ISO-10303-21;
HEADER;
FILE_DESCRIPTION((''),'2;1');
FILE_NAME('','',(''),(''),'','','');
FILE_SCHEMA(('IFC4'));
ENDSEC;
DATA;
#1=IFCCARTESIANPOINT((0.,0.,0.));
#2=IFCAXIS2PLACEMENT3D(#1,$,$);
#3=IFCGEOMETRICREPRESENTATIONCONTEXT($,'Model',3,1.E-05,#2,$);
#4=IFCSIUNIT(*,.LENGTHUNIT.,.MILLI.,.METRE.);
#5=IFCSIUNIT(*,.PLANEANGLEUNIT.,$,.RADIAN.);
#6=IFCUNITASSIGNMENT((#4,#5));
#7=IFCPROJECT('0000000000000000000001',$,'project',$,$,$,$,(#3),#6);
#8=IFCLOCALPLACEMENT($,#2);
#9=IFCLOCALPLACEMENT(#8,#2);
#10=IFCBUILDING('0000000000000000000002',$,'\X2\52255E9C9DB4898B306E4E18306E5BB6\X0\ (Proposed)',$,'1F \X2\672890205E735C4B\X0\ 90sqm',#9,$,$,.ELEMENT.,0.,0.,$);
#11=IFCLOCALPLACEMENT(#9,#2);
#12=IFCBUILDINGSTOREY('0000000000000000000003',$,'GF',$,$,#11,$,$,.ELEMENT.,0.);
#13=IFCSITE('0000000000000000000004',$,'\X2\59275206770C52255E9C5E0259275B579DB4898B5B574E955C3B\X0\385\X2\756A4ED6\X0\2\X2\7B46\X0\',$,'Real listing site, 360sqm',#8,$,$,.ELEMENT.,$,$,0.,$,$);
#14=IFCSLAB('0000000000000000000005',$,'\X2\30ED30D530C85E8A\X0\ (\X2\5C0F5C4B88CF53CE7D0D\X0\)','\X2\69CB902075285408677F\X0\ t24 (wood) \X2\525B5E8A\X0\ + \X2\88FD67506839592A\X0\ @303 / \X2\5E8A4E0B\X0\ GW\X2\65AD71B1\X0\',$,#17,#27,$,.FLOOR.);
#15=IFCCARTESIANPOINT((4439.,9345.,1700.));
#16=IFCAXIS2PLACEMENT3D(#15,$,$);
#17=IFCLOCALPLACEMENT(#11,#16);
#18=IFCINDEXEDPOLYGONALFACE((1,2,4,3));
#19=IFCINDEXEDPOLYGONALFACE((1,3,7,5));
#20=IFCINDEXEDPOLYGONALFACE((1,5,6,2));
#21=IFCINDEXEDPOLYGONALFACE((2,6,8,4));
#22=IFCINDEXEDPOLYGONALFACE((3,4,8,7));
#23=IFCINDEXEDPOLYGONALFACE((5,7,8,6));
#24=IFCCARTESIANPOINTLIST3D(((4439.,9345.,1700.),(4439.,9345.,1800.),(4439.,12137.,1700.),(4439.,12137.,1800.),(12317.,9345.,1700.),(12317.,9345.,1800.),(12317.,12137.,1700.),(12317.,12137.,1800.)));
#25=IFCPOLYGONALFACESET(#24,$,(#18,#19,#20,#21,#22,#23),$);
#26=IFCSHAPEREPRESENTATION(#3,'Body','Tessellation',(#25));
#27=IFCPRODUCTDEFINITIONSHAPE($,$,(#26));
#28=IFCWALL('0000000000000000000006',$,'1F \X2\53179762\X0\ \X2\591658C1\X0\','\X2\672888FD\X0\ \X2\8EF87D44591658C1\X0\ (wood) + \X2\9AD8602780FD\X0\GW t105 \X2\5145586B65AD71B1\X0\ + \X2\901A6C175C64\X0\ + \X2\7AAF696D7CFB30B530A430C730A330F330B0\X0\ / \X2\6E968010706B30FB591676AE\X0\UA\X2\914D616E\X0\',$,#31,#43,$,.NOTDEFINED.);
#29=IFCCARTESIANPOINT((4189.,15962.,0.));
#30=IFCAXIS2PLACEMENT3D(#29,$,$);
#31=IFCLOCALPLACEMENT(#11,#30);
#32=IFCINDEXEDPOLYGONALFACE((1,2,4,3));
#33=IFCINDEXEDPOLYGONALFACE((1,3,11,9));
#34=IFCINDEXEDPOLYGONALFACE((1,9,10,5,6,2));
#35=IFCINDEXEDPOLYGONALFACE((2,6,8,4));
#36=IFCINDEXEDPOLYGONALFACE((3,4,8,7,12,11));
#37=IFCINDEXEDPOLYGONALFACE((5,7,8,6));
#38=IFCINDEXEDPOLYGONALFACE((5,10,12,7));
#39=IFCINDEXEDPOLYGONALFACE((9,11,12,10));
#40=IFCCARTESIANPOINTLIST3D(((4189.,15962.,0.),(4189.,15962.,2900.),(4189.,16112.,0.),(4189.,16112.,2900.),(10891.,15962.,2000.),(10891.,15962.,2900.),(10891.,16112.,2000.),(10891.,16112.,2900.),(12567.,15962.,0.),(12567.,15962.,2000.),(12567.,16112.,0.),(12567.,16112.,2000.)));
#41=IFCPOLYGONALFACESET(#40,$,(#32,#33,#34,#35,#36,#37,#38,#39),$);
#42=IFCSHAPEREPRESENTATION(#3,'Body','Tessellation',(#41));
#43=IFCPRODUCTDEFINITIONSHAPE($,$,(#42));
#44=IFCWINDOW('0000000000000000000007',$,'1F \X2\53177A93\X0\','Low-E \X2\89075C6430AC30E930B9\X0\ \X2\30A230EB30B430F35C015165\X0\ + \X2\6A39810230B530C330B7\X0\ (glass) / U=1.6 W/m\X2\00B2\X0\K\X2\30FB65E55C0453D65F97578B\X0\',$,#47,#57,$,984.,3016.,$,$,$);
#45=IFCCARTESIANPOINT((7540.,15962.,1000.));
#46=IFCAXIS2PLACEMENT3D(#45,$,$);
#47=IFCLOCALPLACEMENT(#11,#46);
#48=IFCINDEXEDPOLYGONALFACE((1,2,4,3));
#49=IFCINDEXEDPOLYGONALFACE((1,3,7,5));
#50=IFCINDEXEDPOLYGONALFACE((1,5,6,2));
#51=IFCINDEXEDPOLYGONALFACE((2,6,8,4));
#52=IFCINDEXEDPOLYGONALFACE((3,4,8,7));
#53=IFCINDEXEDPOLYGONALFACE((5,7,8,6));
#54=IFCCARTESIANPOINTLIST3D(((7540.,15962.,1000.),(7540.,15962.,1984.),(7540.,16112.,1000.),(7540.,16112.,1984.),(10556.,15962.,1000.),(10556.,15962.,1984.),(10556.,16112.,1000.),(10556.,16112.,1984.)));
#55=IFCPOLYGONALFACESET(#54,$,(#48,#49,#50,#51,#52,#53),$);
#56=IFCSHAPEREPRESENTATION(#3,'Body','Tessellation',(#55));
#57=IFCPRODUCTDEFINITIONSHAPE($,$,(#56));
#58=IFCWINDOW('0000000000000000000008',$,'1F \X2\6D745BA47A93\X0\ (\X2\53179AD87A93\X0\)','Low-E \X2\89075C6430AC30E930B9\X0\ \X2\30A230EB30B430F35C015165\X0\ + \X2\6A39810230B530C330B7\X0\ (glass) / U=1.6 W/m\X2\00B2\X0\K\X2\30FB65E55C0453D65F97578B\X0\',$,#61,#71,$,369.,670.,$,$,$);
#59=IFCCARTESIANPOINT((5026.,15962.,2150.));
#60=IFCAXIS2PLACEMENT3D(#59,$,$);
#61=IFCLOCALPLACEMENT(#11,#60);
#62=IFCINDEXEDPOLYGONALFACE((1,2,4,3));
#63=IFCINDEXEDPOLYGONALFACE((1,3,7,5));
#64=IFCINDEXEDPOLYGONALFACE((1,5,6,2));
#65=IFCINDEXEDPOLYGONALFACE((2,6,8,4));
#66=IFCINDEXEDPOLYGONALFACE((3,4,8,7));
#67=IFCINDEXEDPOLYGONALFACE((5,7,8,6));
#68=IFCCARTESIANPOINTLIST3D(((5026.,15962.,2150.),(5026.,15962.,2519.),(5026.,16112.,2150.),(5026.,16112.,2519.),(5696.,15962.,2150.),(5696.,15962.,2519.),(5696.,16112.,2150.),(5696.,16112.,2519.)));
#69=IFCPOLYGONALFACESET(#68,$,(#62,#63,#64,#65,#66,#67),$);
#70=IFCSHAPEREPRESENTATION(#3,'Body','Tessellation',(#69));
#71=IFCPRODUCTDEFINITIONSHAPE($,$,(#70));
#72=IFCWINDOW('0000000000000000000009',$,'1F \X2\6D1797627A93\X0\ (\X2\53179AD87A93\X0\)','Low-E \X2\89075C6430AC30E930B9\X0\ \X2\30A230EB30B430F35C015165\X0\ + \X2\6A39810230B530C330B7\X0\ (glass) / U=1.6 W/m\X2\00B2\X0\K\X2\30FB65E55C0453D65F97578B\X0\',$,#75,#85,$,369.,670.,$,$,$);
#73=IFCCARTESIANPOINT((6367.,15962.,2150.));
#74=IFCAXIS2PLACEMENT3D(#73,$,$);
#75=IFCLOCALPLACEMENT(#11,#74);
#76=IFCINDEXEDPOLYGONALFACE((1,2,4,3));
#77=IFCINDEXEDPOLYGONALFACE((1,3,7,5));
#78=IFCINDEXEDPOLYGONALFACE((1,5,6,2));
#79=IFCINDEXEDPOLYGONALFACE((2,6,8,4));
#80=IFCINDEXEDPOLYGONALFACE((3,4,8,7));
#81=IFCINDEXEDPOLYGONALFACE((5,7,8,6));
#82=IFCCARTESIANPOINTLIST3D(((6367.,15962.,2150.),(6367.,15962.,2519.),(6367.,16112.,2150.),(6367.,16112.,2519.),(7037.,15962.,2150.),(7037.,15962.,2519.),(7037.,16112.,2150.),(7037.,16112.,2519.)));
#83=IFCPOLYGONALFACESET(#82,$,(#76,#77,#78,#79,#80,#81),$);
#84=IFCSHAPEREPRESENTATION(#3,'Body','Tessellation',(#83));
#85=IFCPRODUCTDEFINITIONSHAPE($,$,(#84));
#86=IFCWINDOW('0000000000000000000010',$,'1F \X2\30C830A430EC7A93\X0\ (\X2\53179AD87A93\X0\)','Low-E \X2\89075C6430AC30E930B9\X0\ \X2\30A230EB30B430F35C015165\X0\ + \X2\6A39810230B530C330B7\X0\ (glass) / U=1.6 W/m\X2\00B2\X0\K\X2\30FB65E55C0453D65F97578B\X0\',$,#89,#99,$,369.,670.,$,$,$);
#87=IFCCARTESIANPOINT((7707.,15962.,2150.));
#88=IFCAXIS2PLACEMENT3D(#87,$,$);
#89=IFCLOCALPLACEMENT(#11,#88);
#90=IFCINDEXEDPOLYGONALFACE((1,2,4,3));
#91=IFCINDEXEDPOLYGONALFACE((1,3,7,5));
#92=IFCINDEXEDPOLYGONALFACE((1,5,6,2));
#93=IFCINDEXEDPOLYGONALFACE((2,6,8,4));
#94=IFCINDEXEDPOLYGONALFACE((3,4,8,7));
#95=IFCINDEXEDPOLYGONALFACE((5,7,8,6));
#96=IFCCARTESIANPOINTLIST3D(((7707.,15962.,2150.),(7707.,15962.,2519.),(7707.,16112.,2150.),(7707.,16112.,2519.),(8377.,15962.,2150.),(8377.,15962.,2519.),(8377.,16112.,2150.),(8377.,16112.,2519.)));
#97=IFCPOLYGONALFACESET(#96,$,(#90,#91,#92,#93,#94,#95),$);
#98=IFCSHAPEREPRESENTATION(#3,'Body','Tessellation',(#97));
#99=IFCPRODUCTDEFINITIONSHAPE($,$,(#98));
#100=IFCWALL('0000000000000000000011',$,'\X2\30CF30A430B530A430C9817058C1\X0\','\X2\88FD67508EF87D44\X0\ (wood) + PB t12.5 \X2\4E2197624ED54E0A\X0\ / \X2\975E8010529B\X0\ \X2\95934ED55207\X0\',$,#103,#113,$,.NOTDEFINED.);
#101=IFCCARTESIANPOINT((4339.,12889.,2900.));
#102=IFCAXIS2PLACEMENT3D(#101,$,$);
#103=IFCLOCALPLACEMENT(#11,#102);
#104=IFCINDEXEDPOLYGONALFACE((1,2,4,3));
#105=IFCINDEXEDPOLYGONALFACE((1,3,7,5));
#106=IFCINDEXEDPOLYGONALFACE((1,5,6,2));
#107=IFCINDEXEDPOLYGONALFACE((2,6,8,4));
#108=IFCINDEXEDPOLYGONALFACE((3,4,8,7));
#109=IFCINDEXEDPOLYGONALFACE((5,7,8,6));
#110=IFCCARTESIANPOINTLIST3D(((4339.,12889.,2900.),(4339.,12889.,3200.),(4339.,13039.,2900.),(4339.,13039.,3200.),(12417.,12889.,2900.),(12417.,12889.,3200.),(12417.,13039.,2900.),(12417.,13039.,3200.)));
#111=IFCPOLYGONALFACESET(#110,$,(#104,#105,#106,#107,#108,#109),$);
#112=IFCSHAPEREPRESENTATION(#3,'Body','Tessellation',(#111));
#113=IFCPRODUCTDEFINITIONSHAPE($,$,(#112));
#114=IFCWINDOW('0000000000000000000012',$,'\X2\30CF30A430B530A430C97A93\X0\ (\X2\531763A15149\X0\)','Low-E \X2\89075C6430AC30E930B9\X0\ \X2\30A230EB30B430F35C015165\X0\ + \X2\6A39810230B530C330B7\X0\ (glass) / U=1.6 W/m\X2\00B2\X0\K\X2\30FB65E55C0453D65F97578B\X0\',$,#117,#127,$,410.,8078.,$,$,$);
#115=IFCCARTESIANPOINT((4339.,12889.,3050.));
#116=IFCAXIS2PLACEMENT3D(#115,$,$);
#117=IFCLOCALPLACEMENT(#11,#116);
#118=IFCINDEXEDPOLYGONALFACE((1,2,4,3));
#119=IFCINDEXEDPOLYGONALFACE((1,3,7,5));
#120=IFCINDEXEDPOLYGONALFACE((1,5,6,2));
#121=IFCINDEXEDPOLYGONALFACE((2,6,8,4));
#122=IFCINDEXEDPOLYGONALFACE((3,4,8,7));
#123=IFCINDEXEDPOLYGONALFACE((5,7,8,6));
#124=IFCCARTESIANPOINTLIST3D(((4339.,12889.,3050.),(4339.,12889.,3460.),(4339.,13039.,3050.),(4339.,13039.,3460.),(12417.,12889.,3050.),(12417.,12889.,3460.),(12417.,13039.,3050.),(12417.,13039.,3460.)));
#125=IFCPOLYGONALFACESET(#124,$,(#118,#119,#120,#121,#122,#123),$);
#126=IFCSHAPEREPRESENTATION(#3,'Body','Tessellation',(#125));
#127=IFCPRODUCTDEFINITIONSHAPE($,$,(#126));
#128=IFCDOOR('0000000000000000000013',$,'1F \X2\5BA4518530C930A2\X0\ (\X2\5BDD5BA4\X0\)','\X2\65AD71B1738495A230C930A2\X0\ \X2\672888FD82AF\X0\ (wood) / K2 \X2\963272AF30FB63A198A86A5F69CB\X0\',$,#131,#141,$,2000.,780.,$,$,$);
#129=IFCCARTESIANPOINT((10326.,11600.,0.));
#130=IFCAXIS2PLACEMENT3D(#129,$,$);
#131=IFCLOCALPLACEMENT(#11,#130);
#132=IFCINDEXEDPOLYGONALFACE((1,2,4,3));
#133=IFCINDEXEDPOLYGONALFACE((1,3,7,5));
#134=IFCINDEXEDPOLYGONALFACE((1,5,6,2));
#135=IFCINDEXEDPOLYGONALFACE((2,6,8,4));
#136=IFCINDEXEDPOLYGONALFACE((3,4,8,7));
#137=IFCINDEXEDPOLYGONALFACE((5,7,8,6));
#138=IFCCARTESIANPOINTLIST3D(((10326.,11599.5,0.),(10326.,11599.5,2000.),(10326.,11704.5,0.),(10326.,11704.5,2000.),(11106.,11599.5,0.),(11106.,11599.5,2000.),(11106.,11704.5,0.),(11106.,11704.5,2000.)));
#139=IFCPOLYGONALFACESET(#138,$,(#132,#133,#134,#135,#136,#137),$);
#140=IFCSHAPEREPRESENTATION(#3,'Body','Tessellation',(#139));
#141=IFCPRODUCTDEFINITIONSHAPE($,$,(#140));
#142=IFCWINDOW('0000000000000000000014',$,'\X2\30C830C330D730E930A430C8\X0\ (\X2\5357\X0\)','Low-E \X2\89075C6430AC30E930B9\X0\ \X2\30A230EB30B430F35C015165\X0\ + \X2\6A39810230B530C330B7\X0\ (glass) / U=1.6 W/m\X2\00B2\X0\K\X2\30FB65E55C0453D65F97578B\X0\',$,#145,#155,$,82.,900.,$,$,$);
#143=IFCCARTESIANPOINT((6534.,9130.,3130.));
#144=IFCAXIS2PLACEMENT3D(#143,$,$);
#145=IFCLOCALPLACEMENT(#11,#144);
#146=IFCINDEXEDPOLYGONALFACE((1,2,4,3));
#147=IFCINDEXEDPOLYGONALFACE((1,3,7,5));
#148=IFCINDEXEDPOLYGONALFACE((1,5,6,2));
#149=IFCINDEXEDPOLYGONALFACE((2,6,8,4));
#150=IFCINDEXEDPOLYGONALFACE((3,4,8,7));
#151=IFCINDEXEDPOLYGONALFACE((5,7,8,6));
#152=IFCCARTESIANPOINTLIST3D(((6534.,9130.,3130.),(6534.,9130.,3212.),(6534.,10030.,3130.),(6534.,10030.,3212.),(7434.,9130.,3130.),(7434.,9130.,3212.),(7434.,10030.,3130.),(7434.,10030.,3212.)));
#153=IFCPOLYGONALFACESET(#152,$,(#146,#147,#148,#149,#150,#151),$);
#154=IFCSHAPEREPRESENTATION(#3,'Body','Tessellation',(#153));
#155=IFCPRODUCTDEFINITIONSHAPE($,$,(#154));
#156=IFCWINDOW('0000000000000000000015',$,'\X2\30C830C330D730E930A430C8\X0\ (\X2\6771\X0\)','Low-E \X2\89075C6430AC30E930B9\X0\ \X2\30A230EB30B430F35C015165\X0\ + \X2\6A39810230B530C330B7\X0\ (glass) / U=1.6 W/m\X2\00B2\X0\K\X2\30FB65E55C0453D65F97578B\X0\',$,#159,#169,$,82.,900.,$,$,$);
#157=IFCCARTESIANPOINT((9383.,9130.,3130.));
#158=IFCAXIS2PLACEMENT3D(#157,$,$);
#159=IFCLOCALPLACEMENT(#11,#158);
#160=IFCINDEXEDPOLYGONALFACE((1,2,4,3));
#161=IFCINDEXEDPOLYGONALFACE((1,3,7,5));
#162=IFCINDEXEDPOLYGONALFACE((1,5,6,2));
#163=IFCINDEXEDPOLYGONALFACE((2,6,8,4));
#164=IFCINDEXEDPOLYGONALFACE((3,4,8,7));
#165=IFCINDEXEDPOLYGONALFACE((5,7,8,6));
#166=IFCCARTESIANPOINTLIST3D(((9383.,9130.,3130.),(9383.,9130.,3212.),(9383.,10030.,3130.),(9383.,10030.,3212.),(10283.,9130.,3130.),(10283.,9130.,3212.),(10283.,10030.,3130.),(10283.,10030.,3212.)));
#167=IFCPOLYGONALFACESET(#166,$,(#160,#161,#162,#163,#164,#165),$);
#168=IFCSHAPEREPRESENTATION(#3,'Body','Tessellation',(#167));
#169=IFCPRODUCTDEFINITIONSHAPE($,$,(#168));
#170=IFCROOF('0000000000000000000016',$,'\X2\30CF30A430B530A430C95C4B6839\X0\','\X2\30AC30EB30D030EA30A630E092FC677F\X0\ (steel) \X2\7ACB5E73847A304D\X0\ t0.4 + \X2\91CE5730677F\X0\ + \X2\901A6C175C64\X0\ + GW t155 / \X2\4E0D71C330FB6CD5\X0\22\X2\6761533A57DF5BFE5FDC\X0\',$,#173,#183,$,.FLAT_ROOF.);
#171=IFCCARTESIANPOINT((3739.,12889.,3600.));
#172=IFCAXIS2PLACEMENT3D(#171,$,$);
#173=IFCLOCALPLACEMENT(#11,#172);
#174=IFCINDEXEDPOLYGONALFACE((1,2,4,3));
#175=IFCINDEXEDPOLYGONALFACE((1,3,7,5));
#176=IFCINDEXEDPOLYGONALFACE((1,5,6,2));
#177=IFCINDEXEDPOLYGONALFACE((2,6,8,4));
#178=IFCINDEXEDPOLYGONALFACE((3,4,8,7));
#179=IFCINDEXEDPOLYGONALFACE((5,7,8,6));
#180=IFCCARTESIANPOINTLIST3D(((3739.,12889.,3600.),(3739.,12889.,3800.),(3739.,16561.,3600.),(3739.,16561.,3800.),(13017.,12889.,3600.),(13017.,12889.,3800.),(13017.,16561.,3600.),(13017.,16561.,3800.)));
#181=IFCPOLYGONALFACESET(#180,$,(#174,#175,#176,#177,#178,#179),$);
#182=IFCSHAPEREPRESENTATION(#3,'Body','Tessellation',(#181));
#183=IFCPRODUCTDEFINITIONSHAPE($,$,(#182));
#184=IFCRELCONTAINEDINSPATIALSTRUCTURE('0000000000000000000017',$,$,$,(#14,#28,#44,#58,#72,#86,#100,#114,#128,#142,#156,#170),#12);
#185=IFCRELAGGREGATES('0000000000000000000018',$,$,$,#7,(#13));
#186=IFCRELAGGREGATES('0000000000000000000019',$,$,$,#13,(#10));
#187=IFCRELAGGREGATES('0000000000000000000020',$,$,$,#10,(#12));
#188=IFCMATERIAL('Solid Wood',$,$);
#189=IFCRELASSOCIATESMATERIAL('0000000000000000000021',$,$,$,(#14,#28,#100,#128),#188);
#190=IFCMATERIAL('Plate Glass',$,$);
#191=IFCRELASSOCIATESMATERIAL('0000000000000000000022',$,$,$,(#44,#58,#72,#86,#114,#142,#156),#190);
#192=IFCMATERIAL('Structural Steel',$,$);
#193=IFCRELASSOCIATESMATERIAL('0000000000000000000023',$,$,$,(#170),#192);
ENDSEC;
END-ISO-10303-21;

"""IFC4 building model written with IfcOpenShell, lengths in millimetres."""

from ifc_helpers import new_model, si_unit, frame, frame_2d, origin, place, context, project, spatial, rectangle, extrude, material, element, fill, save


model = new_model("IFC4")

# Units and contexts
model_context = context("Model", 3, precision=1e-05, world=origin())
ifc_project = project(units=[si_unit("LENGTHUNIT", "METRE", prefix="MILLI"), si_unit("PLANEANGLEUNIT", "RADIAN")], contexts=[model_context])

# Site, building, storey
site_placement = place(None, origin())
site = spatial("IfcSite", under=ifc_project, at=site_placement, Name="大分県別府市大字鶴見字井尻385番他2筆", ObjectType="Real listing site, 360sqm", CompositionType="ELEMENT", RefElevation=0.0)
building_placement = place(site_placement, origin())
building = spatial("IfcBuilding", under=site, at=building_placement, Name="別府鶴見の丘の家 (Proposed)", ObjectType="1F 木造平屋 90sqm", CompositionType="ELEMENT", ElevationOfRefHeight=0.0, ElevationOfTerrain=0.0)
storey_placement = place(building_placement, origin())
storey = spatial("IfcBuildingStorey", under=building, at=storey_placement, Name="GF", CompositionType="ELEMENT", Elevation=0.0)

# Slab
ifc_material_1 = material(Name="Solid Wood")
slab_placement = place(storey_placement, frame((4439.0, 9345.0, 1700.0)))
element("IfcSlab", 1, at=slab_placement, inside=storey, material=ifc_material_1, Name="ロフト床 (小屋裏収納)", Description="構造用合板 t24 (wood) 剛床 + 製材根太 @303 / 床下 GW断熱", PredefinedType="FLOOR", context=model_context, shape_type="SweptSolid", body=[
    extrude(rectangle(XDim=7878.0, YDim=2792.0, at=frame_2d((3939.0, 1396.0))), frame((4439.0, 9345.0, 1700.0)), (0.0, 0.0, 1.0), 100.0),
])

# Wall, openings, windows
wall_1_placement = place(storey_placement, frame((4189.0, 15962.0, 0.0)))
wall_1 = element("IfcWall", 2, at=wall_1_placement, inside=storey, material=ifc_material_1, Name="1F 北面 外壁", Description="木製 軸組外壁 (wood) + 高性能GW t105 充填断熱 + 通気層 + 窯業系サイディング / 準耐火・外皮UA配慮", PredefinedType="NOTDEFINED", context=model_context, shape_type="SweptSolid", body=[
    extrude(rectangle(XDim=8378.0, YDim=150.0, at=frame_2d((4189.0, 75.0))), frame((4189.0, 15962.0, 0.0)), (0.0, 0.0, 1.0), 2900.0),
])
opening_1_placement = place(storey_placement, frame((7540.0, 15962.0, 1000.0)))
opening_1 = element("IfcOpeningElement", 3, at=opening_1_placement, cuts=wall_1, PredefinedType="NOTDEFINED", context=model_context, shape_type="SweptSolid", body=[
    extrude(rectangle(XDim=3016.0, YDim=150.0, at=frame_2d((1508.0, 75.0))), frame((7540.0, 15962.0, 1000.0)), (0.0, 0.0, 1.0), 984.0),
])
opening_2_placement = place(storey_placement, frame((5026.0, 15962.0, 2150.0)))
opening_2 = element("IfcOpeningElement", 4, at=opening_2_placement, cuts=wall_1, PredefinedType="NOTDEFINED", context=model_context, shape_type="SweptSolid", body=[
    extrude(rectangle(XDim=670.0, YDim=150.0, at=frame_2d((335.0, 75.0))), frame((5026.0, 15962.0, 2150.0)), (0.0, 0.0, 1.0), 369.0),
])
opening_3_placement = place(storey_placement, frame((6367.0, 15962.0, 2150.0)))
opening_3 = element("IfcOpeningElement", 5, at=opening_3_placement, cuts=wall_1, PredefinedType="NOTDEFINED", context=model_context, shape_type="SweptSolid", body=[
    extrude(rectangle(XDim=670.0, YDim=150.0, at=frame_2d((335.0, 75.0))), frame((6367.0, 15962.0, 2150.0)), (0.0, 0.0, 1.0), 369.0),
])
opening_4_placement = place(storey_placement, frame((7707.0, 15962.0, 2150.0)))
opening_4 = element("IfcOpeningElement", 6, at=opening_4_placement, cuts=wall_1, PredefinedType="NOTDEFINED", context=model_context, shape_type="SweptSolid", body=[
    extrude(rectangle(XDim=670.0, YDim=150.0, at=frame_2d((335.0, 75.0))), frame((7707.0, 15962.0, 2150.0)), (0.0, 0.0, 1.0), 369.0),
])
ifc_material_2 = material(Name="Plate Glass")
window_1_placement = place(storey_placement, frame((7540.0, 15962.0, 1000.0)))
window_1 = element("IfcWindow", 7, at=window_1_placement, inside=storey, material=ifc_material_2, Name="1F 北窓", Description="Low-E 複層ガラス アルゴン封入 + 樹脂サッシ (glass) / U=1.6 W/m²K・日射取得型", OverallHeight=984.0, OverallWidth=3016.0, context=model_context, shape_type="SweptSolid", body=[
    extrude(rectangle(XDim=3016.0, YDim=150.0, at=frame_2d((1508.0, 75.0))), frame((7540.0, 15962.0, 1000.0)), (0.0, 0.0, 1.0), 984.0),
])
fill(opening_1, window_1)
window_2_placement = place(storey_placement, frame((5026.0, 15962.0, 2150.0)))
window_2 = element("IfcWindow", 8, at=window_2_placement, inside=storey, material=ifc_material_2, Name="1F 浴室窓 (北高窓)", Description="Low-E 複層ガラス アルゴン封入 + 樹脂サッシ (glass) / U=1.6 W/m²K・日射取得型", OverallHeight=369.0, OverallWidth=670.0, context=model_context, shape_type="SweptSolid", body=[
    extrude(rectangle(XDim=670.0, YDim=150.0, at=frame_2d((335.0, 75.0))), frame((5026.0, 15962.0, 2150.0)), (0.0, 0.0, 1.0), 369.0),
])
fill(opening_2, window_2)
window_3_placement = place(storey_placement, frame((6367.0, 15962.0, 2150.0)))
window_3 = element("IfcWindow", 9, at=window_3_placement, inside=storey, material=ifc_material_2, Name="1F 洗面窓 (北高窓)", Description="Low-E 複層ガラス アルゴン封入 + 樹脂サッシ (glass) / U=1.6 W/m²K・日射取得型", OverallHeight=369.0, OverallWidth=670.0, context=model_context, shape_type="SweptSolid", body=[
    extrude(rectangle(XDim=670.0, YDim=150.0, at=frame_2d((335.0, 75.0))), frame((6367.0, 15962.0, 2150.0)), (0.0, 0.0, 1.0), 369.0),
])
fill(opening_3, window_3)
window_4_placement = place(storey_placement, frame((7707.0, 15962.0, 2150.0)))
window_4 = element("IfcWindow", 10, at=window_4_placement, inside=storey, material=ifc_material_2, Name="1F トイレ窓 (北高窓)", Description="Low-E 複層ガラス アルゴン封入 + 樹脂サッシ (glass) / U=1.6 W/m²K・日射取得型", OverallHeight=369.0, OverallWidth=670.0, context=model_context, shape_type="SweptSolid", body=[
    extrude(rectangle(XDim=670.0, YDim=150.0, at=frame_2d((335.0, 75.0))), frame((7707.0, 15962.0, 2150.0)), (0.0, 0.0, 1.0), 369.0),
])
fill(opening_4, window_4)

# Wall, opening, window
wall_2_placement = place(storey_placement, frame((4339.0, 12889.0, 2900.0)))
wall_2 = element("IfcWall", 11, at=wall_2_placement, inside=storey, material=ifc_material_1, Name="ハイサイド腰壁", Description="製材軸組 (wood) + PB t12.5 両面仕上 / 非耐力 間仕切", PredefinedType="NOTDEFINED", context=model_context, shape_type="SweptSolid", body=[
    extrude(rectangle(XDim=8078.0, YDim=150.0, at=frame_2d((4039.0, 75.0))), frame((4339.0, 12889.0, 2900.0)), (0.0, 0.0, 1.0), 700.0),
])
opening_5_placement = place(storey_placement, frame((4339.0, 12889.0, 3050.0)))
opening_5 = element("IfcOpeningElement", 12, at=opening_5_placement, cuts=wall_2, PredefinedType="NOTDEFINED", context=model_context, shape_type="SweptSolid", body=[
    extrude(rectangle(XDim=8078.0, YDim=150.0, at=frame_2d((4039.0, 75.0))), frame((4339.0, 12889.0, 3050.0)), (0.0, 0.0, 1.0), 410.0),
])
window_5_placement = place(storey_placement, frame((4339.0, 12889.0, 3050.0)))
window_5 = element("IfcWindow", 13, at=window_5_placement, inside=storey, material=ifc_material_2, Name="ハイサイド窓 (北採光)", Description="Low-E 複層ガラス アルゴン封入 + 樹脂サッシ (glass) / U=1.6 W/m²K・日射取得型", OverallHeight=410.0, OverallWidth=8078.0, context=model_context, shape_type="SweptSolid", body=[
    extrude(rectangle(XDim=8078.0, YDim=150.0, at=frame_2d((4039.0, 75.0))), frame((4339.0, 12889.0, 3050.0)), (0.0, 0.0, 1.0), 410.0),
])
fill(opening_5, window_5)

# Door
door_1_placement = place(storey_placement, frame((10326.0, 11600.0, 0.0)))
element("IfcDoor", 14, at=door_1_placement, inside=storey, material=ifc_material_1, Name="1F 室内ドア (寝室)", Description="断熱玄関ドア 木製芯 (wood) / K2 防犯・採風機構", OverallHeight=2000.0, OverallWidth=780.0, context=model_context, shape_type="SweptSolid", body=[
    extrude(rectangle(XDim=780.0, YDim=105.0, at=frame_2d((390.0, 52.0))), frame((10326.0, 11600.0, 0.0)), (0.0, 0.0, 1.0), 2000.0),
])

# Windows
window_6_placement = place(storey_placement, frame((6534.0, 9130.0, 3130.0)))
element("IfcWindow", 15, at=window_6_placement, inside=storey, material=ifc_material_2, Name="トップライト (南)", Description="Low-E 複層ガラス アルゴン封入 + 樹脂サッシ (glass) / U=1.6 W/m²K・日射取得型", OverallHeight=82.0, OverallWidth=900.0, context=model_context, shape_type="SweptSolid", body=[
    extrude(rectangle(XDim=900.0, YDim=900.0, at=frame_2d((450.0, 450.0))), frame((6534.0, 9130.0, 3130.0)), (0.0, 0.0, 1.0), 82.0),
])
window_7_placement = place(storey_placement, frame((9383.0, 9130.0, 3130.0)))
element("IfcWindow", 16, at=window_7_placement, inside=storey, material=ifc_material_2, Name="トップライト (東)", Description="Low-E 複層ガラス アルゴン封入 + 樹脂サッシ (glass) / U=1.6 W/m²K・日射取得型", OverallHeight=82.0, OverallWidth=900.0, context=model_context, shape_type="SweptSolid", body=[
    extrude(rectangle(XDim=900.0, YDim=900.0, at=frame_2d((450.0, 450.0))), frame((9383.0, 9130.0, 3130.0)), (0.0, 0.0, 1.0), 82.0),
])

# Roof
ifc_material_3 = material(Name="Structural Steel")
roof_placement = place(storey_placement, frame((3739.0, 12889.0, 3600.0)))
element("IfcRoof", 17, at=roof_placement, inside=storey, material=ifc_material_3, Name="ハイサイド屋根", Description="ガルバリウム鋼板 (steel) 立平葺き t0.4 + 野地板 + 通気層 + GW t155 / 不燃・法22条区域対応", PredefinedType="FLAT_ROOF", context=model_context, shape_type="SweptSolid", body=[
    extrude(rectangle(XDim=9278.0, YDim=3672.0, at=frame_2d((4639.0, 1836.0))), frame((3739.0, 12889.0, 3600.0)), (0.0, 0.0, 1.0), 200.0),
])

save(model, "model.ifc")
